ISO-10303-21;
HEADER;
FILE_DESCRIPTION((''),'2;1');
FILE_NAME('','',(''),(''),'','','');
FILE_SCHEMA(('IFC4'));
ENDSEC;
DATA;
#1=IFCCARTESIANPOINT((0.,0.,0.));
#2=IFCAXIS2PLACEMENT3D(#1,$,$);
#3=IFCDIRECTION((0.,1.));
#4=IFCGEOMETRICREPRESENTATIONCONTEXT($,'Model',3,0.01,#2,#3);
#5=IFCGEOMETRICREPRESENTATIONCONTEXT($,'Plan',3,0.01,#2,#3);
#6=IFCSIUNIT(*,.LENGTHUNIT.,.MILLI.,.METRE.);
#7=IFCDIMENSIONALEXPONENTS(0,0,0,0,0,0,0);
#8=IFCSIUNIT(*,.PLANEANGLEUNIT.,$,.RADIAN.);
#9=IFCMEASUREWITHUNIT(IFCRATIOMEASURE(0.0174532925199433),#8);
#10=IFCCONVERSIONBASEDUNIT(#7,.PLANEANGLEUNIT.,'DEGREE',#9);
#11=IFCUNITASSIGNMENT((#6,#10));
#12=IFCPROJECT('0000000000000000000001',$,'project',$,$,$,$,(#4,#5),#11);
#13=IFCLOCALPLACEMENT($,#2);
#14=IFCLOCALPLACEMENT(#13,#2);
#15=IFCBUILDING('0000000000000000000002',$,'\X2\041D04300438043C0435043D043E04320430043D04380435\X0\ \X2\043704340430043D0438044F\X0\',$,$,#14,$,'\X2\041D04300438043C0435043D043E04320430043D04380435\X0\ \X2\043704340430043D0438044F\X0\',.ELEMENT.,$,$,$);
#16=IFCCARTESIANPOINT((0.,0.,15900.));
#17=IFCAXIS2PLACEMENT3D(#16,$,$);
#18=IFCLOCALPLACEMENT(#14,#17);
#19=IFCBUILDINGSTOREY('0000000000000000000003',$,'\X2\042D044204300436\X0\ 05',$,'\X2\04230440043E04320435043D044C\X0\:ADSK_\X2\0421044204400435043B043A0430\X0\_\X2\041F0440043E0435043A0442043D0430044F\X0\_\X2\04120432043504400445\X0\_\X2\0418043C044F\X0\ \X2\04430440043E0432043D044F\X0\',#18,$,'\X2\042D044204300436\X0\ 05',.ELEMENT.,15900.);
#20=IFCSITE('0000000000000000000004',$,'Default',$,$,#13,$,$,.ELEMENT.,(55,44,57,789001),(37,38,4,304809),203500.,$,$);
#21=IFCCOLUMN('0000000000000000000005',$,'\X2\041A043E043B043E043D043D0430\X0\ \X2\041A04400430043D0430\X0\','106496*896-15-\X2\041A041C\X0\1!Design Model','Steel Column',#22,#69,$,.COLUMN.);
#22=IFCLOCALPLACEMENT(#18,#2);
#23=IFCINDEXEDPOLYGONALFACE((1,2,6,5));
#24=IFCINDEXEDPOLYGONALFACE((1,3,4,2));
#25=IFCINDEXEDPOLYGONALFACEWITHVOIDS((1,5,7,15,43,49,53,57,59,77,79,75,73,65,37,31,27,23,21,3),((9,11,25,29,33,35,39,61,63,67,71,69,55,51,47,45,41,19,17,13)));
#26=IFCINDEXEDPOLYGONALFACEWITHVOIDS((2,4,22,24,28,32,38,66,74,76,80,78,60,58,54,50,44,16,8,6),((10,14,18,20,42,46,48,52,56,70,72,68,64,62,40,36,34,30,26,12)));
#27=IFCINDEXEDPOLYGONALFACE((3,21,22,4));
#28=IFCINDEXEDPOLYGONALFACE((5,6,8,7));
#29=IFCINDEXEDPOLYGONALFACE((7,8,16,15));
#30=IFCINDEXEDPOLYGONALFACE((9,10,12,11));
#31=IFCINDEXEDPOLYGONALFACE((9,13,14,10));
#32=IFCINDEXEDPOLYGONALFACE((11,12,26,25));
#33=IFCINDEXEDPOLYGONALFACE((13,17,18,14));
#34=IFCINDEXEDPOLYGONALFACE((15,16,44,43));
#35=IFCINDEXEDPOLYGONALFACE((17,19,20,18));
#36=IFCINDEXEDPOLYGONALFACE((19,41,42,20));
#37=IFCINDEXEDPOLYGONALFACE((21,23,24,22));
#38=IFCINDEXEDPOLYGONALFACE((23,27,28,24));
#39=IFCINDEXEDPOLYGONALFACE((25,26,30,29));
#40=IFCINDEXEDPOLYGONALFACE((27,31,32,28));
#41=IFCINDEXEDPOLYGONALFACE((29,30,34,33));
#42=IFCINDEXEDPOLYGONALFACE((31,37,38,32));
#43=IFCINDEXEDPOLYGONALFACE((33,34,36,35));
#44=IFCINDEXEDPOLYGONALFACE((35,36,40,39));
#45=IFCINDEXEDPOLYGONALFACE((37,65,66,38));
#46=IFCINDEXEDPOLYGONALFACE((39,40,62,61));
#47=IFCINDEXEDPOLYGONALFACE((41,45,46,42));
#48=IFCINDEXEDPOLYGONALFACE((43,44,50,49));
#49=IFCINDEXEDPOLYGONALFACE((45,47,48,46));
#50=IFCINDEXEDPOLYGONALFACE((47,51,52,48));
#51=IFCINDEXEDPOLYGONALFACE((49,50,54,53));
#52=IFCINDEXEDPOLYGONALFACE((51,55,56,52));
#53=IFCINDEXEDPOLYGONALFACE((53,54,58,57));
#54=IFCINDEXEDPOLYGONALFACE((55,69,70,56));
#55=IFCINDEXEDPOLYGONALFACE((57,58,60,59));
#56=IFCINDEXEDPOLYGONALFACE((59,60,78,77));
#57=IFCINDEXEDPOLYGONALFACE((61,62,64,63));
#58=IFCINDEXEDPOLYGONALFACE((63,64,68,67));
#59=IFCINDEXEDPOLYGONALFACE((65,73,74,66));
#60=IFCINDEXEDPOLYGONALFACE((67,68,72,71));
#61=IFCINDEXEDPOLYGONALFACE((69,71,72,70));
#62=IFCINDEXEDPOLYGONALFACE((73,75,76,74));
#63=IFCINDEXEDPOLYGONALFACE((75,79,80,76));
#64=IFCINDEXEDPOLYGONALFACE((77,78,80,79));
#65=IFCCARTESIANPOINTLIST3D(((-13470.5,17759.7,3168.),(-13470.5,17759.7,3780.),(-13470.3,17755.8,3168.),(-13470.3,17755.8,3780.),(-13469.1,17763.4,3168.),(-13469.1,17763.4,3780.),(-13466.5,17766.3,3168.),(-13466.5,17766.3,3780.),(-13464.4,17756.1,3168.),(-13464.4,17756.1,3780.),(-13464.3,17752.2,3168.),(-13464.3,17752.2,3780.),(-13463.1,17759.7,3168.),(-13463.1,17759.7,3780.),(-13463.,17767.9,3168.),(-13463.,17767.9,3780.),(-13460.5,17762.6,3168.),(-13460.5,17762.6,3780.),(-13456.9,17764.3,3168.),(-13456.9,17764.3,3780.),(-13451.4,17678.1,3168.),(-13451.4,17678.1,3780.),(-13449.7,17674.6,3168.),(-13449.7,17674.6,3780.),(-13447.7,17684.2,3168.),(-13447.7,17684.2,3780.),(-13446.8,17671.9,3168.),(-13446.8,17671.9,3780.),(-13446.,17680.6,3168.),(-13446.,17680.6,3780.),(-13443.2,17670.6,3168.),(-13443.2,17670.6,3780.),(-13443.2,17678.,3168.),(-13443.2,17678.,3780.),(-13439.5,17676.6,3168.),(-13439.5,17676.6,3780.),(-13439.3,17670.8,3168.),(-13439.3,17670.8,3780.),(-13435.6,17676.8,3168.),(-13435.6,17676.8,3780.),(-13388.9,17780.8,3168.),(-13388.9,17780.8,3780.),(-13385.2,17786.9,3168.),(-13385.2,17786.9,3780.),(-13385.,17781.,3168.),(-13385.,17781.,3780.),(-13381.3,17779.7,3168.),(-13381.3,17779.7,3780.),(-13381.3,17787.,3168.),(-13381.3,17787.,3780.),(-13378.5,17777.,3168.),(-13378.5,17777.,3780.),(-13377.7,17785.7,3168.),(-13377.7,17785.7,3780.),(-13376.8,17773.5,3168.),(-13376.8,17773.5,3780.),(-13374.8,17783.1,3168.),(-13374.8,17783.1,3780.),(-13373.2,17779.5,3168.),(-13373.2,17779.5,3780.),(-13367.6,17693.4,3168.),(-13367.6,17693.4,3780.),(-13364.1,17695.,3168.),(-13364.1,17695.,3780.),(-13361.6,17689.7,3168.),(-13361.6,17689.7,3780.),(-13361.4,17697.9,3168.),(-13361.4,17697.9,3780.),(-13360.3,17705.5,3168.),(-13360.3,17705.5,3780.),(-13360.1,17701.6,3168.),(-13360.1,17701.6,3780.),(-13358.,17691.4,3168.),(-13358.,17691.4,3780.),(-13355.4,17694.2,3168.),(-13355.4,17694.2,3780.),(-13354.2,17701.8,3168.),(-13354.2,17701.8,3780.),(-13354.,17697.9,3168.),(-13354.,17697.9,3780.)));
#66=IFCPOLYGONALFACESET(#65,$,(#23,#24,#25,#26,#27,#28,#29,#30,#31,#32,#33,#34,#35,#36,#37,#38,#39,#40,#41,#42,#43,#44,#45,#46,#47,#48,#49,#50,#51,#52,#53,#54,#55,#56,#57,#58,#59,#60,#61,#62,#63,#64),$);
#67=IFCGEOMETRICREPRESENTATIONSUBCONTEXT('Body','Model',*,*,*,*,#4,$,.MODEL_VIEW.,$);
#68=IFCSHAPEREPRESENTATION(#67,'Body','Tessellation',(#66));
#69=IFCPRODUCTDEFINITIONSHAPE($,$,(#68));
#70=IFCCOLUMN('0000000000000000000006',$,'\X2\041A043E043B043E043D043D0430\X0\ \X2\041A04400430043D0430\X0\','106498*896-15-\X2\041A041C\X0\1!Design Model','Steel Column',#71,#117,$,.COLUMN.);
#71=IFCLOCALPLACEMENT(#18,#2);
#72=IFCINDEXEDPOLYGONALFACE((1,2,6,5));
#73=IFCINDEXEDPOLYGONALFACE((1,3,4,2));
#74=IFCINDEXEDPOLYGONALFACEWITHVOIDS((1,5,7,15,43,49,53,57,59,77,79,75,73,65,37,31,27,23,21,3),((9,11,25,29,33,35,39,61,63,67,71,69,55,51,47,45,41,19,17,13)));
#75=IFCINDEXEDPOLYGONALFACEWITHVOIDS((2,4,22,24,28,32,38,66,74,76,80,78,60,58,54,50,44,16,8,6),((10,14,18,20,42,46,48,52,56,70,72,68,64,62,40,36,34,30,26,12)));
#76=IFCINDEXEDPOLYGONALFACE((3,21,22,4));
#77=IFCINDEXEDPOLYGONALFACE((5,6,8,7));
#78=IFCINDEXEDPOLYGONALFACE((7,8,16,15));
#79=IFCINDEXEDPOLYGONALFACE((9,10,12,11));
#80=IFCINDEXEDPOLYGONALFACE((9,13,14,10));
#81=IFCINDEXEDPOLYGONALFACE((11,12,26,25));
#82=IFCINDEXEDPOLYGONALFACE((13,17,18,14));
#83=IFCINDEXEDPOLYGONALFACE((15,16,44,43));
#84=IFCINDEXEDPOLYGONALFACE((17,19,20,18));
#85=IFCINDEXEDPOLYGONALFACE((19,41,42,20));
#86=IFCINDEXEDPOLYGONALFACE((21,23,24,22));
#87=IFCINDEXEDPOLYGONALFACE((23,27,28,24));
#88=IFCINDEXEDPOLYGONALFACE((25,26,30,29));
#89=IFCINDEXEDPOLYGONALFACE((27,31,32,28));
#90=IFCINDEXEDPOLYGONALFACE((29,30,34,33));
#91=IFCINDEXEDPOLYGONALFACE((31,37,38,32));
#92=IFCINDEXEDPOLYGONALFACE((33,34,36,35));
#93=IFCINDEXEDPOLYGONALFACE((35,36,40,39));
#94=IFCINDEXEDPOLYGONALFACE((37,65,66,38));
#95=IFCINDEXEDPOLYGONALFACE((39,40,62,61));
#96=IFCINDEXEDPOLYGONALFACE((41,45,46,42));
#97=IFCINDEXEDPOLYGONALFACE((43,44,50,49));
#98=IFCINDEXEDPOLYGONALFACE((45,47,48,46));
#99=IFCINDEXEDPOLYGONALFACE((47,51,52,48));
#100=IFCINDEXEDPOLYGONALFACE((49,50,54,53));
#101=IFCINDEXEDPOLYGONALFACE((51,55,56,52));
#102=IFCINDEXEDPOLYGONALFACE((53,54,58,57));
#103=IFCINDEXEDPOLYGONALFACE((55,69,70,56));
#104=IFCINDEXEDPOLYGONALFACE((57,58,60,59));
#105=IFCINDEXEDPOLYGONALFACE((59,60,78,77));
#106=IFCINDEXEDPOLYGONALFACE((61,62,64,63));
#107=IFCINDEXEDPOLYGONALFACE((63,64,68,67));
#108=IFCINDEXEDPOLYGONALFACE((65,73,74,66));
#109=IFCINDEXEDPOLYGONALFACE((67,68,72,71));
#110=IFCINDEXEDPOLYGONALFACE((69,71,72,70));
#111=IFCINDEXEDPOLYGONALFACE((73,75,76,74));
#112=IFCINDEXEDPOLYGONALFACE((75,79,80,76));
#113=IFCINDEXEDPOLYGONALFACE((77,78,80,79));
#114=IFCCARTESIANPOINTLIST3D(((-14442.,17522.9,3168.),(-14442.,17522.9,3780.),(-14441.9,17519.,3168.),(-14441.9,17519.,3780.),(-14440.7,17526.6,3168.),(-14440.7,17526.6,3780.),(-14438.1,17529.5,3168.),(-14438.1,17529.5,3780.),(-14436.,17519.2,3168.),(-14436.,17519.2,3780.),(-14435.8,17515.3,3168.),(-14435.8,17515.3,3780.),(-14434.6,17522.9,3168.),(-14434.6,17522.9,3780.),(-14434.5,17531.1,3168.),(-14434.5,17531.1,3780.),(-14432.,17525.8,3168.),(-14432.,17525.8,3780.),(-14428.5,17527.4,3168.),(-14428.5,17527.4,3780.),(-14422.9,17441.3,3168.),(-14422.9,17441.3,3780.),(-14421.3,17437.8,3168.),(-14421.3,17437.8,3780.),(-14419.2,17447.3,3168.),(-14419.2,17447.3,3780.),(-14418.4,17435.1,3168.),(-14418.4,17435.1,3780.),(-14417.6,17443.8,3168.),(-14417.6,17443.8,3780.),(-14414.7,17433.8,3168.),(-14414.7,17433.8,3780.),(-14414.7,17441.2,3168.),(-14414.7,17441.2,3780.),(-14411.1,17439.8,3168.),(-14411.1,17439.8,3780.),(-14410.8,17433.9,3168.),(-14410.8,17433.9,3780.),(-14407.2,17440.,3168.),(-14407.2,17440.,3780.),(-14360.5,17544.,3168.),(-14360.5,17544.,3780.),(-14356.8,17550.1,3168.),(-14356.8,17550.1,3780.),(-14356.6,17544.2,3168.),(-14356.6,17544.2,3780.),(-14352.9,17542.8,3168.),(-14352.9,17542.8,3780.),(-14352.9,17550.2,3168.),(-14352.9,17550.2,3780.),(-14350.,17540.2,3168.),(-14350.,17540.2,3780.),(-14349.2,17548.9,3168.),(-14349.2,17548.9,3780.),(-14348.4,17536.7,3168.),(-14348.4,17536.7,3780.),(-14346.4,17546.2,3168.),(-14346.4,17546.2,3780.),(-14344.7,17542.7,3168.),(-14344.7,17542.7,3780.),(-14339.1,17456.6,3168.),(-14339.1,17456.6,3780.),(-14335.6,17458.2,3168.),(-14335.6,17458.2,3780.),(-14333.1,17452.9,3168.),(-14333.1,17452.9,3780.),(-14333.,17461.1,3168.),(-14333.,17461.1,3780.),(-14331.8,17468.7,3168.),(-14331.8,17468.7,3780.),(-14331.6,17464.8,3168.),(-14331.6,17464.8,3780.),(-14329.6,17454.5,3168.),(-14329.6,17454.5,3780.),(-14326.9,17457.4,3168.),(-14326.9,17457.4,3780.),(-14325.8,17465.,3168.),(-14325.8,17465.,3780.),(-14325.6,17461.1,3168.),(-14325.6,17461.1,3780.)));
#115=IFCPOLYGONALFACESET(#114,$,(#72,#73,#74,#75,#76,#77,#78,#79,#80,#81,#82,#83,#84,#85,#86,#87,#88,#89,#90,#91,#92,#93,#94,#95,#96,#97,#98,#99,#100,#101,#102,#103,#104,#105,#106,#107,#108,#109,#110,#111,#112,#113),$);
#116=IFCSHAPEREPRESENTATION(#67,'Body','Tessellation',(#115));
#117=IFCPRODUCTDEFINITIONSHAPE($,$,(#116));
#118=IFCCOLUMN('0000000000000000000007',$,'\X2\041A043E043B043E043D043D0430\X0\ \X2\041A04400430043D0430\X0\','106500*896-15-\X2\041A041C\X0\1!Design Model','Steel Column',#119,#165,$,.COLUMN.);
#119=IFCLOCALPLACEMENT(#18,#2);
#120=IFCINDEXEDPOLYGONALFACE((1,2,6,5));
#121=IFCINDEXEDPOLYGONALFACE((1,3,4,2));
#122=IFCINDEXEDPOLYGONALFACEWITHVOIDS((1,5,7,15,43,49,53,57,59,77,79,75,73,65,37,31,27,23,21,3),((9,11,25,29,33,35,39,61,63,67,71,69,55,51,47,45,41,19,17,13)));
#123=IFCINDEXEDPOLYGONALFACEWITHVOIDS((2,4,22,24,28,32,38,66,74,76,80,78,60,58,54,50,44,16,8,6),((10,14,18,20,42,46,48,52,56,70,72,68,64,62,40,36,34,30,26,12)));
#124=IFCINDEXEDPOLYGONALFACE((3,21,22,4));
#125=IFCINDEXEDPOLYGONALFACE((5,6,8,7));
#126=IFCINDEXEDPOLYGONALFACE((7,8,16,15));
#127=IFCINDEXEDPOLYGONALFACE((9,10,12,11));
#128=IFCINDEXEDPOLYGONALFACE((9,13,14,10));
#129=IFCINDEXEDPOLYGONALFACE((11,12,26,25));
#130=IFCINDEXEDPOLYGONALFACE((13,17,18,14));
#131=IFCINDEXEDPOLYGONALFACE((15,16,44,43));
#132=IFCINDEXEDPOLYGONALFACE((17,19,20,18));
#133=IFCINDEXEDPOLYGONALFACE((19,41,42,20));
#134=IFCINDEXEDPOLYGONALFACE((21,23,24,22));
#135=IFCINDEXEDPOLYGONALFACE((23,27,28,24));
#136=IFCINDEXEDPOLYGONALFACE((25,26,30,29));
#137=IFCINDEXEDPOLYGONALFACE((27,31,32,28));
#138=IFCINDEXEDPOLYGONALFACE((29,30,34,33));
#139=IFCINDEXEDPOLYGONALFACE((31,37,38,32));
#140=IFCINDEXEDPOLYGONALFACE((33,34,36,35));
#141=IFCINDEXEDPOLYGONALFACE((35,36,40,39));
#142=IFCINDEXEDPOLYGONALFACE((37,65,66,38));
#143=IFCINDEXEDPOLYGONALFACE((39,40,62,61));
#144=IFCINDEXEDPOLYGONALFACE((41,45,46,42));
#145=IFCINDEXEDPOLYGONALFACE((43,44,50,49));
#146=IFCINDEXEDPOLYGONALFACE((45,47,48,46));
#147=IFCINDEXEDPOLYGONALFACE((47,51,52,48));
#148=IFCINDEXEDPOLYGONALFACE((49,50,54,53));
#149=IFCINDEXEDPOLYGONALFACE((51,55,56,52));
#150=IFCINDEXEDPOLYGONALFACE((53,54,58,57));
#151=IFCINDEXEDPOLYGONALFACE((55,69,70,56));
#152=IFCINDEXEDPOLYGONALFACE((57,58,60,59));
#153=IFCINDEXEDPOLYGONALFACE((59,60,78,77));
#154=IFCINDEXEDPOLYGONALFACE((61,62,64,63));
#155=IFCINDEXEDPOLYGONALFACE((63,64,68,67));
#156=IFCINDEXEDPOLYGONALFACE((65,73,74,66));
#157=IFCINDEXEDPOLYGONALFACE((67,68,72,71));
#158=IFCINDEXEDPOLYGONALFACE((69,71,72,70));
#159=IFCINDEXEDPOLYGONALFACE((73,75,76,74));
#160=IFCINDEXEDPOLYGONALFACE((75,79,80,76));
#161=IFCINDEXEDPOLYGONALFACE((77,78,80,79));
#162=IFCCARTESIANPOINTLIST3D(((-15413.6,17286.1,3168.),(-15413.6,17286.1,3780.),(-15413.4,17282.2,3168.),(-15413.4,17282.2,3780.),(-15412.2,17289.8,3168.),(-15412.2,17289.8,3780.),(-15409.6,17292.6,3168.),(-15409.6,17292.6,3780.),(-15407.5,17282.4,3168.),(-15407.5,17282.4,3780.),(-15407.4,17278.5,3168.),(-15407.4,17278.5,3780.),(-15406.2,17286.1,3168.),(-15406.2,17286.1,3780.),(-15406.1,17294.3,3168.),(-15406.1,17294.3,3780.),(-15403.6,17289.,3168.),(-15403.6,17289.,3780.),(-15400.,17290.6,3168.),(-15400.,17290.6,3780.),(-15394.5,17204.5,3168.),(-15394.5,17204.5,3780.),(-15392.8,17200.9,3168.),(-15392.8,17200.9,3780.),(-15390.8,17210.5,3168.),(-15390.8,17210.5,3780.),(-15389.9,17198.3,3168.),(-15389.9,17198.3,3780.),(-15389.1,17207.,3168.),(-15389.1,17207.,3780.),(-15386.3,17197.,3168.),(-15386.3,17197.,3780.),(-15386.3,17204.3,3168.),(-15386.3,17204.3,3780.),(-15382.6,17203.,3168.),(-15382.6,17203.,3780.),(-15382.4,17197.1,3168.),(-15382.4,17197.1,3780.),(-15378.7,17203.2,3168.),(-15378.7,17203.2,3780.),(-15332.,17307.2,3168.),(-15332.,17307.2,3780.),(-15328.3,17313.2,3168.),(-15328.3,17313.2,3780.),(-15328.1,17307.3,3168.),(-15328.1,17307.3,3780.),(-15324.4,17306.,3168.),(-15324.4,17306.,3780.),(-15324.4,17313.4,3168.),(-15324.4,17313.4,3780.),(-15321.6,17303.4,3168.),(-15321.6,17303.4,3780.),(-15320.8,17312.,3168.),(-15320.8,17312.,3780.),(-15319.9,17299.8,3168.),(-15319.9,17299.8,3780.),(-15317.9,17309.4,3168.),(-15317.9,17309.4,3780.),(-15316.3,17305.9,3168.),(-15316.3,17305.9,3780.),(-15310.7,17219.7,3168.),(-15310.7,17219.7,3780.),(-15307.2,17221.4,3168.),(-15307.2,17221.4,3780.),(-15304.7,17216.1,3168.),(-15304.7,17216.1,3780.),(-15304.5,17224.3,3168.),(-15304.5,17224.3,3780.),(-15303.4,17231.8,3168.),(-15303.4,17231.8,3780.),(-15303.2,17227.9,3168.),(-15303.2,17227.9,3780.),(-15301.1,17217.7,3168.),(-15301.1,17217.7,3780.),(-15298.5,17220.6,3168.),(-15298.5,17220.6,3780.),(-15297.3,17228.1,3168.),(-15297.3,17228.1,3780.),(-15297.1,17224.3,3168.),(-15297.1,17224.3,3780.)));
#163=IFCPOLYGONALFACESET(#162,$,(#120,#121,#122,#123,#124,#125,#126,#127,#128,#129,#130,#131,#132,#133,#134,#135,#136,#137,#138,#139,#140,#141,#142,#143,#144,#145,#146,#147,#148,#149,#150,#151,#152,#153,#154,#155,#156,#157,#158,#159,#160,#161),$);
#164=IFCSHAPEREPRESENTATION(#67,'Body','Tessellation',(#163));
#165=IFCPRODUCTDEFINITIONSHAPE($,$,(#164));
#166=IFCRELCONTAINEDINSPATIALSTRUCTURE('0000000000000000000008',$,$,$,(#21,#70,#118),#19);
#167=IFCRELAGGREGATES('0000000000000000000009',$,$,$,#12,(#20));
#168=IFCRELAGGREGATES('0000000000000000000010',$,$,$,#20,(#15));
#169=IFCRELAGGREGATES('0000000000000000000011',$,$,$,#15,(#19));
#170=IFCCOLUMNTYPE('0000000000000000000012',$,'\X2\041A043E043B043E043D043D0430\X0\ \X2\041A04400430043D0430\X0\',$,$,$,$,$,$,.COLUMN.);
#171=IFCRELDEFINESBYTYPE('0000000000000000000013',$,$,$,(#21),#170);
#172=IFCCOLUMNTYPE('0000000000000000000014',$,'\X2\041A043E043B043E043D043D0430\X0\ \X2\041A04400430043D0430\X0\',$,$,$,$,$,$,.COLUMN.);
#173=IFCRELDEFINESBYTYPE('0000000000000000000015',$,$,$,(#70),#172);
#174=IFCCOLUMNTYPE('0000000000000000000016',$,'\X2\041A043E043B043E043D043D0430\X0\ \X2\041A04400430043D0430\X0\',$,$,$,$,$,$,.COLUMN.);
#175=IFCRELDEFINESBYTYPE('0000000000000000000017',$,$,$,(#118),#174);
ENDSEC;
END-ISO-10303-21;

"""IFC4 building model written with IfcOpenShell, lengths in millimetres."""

from ifc_helpers import new_model, entity, si_unit, converted_unit, direction, frame, origin, place, context, subcontext, project, spatial, indexed_curve, outline, extrude, type_object, element, save


model = new_model("IFC4")

# Units and contexts
model_context = context("Model", 3, precision=0.01, world=origin(), true_north=direction((0.0, 1.0)))
plan_context = context("Plan", 3, precision=0.01, world=origin(), true_north=direction((0.0, 1.0)))
body_context = subcontext(model_context, "Body", "Model", "MODEL_VIEW")
ifc_project = project(units=[si_unit("LENGTHUNIT", "METRE", prefix="MILLI"), converted_unit("PLANEANGLEUNIT", "DEGREE", entity("IfcRatioMeasure", 0.0174532925199433), si_unit("PLANEANGLEUNIT", "RADIAN"), dimensions=[0, 0, 0, 0, 0, 0, 0])], contexts=[model_context, plan_context])

# Site, building, storey
site_placement = place(None, origin())
site = spatial("IfcSite", under=ifc_project, at=site_placement, Name="Default", CompositionType="ELEMENT", RefLatitude=(55, 44, 57, 789001), RefLongitude=(37, 38, 4, 304809), RefElevation=203500.0)
building_placement = place(site_placement, origin())
building = spatial("IfcBuilding", under=site, at=building_placement, Name="Наименование здания", LongName="Наименование здания", CompositionType="ELEMENT")
storey_placement = place(building_placement, frame((0.0, 0.0, 15900.0)))
storey = spatial("IfcBuildingStorey", under=building, at=storey_placement, Name="Этаж 05", ObjectType="Уровень:ADSK_Стрелка_Проектная_Вверх_Имя уровня", LongName="Этаж 05", CompositionType="ELEMENT", Elevation=15900.0)

# Columns
placement = place(storey_placement, origin())
column_type_1 = type_object("IfcColumnType", Name="Колонна Крана", PredefinedType="COLUMN")
element("IfcColumn", 1, at=placement, inside=storey, type_object=column_type_1, Name="Колонна Крана", Description="106496*896-15-КМ1!Design Model", ObjectType="Steel Column", PredefinedType="COLUMN", context=body_context, shape_type="SweptSolid", body=[
    extrude(outline(indexed_curve([(29.5, -56.8), (33.4, -56.8), (37.0, -55.3), (39.7, -52.6), (41.2, -49.0), (56.8, 29.5), (56.8, 33.4), (55.3, 37.0), (52.6, 39.7), (49.0, 41.2), (-29.5, 56.8), (-33.4, 56.8), (-37.0, 55.3), (-39.7, 52.6), (-41.2, 49.0), (-56.8, -29.5), (-56.8, -33.4), (-55.3, -37.0), (-52.6, -39.7), (-49.0, -41.2), (29.5, -56.8)], self_intersect=False), holes=[indexed_curve([(-43.1, -37.3), (-46.7, -35.8), (-49.5, -33.1), (-51.0, -29.5), (-51.0, -25.5), (-37.3, 43.1), (-35.8, 46.7), (-33.1, 49.5), (-29.5, 51.0), (-25.5, 51.0), (43.1, 37.3), (46.7, 35.8), (49.5, 33.1), (51.0, 29.5), (51.0, 25.5), (37.3, -43.1), (35.8, -46.7), (33.1, -49.5), (29.5, -51.0), (25.5, -51.0), (-43.1, -37.3)], self_intersect=False)]), frame((-13412.3, 17728.8, 3168.0), z_axis=(0.0, 0.0, 1.0), x_axis=(0.906681, 0.421816, 0.0)), (0.0, 0.0, 1.0), 612.0),
])
column_type_2 = type_object("IfcColumnType", Name="Колонна Крана", PredefinedType="COLUMN")
element("IfcColumn", 2, at=placement, inside=storey, type_object=column_type_2, Name="Колонна Крана", Description="106498*896-15-КМ1!Design Model", ObjectType="Steel Column", PredefinedType="COLUMN", context=body_context, shape_type="SweptSolid", body=[
    extrude(outline(indexed_curve([(29.5, -56.8), (33.4, -56.8), (37.0, -55.3), (39.7, -52.6), (41.2, -49.0), (56.8, 29.5), (56.8, 33.4), (55.3, 37.0), (52.6, 39.7), (49.0, 41.2), (-29.5, 56.8), (-33.4, 56.8), (-37.0, 55.3), (-39.7, 52.6), (-41.2, 49.0), (-56.8, -29.5), (-56.8, -33.4), (-55.3, -37.0), (-52.6, -39.7), (-49.0, -41.2), (29.5, -56.8)], self_intersect=False), holes=[indexed_curve([(-43.1, -37.3), (-46.7, -35.8), (-49.5, -33.1), (-51.0, -29.5), (-51.0, -25.5), (-37.3, 43.1), (-35.8, 46.7), (-33.1, 49.5), (-29.5, 51.0), (-25.5, 51.0), (43.1, 37.3), (46.7, 35.8), (49.5, 33.1), (51.0, 29.5), (51.0, 25.5), (37.3, -43.1), (35.8, -46.7), (33.1, -49.5), (29.5, -51.0), (25.5, -51.0), (-43.1, -37.3)], self_intersect=False)]), frame((-14383.8, 17492.0, 3168.0), z_axis=(0.0, 0.0, 1.0), x_axis=(0.906681, 0.421816, 0.0)), (0.0, 0.0, 1.0), 612.0),
])
column_type_3 = type_object("IfcColumnType", Name="Колонна Крана", PredefinedType="COLUMN")
element("IfcColumn", 3, at=placement, inside=storey, type_object=column_type_3, Name="Колонна Крана", Description="106500*896-15-КМ1!Design Model", ObjectType="Steel Column", PredefinedType="COLUMN", context=body_context, shape_type="SweptSolid", body=[
    extrude(outline(indexed_curve([(29.5, -56.8), (33.4, -56.8), (37.0, -55.3), (39.7, -52.6), (41.2, -49.0), (56.8, 29.5), (56.8, 33.4), (55.3, 37.0), (52.6, 39.7), (49.0, 41.2), (-29.5, 56.8), (-33.4, 56.8), (-37.0, 55.3), (-39.7, 52.6), (-41.2, 49.0), (-56.8, -29.5), (-56.8, -33.4), (-55.3, -37.0), (-52.6, -39.7), (-49.0, -41.2), (29.5, -56.8)], self_intersect=False), holes=[indexed_curve([(-43.1, -37.3), (-46.7, -35.8), (-49.5, -33.1), (-51.0, -29.5), (-51.0, -25.5), (-37.3, 43.1), (-35.8, 46.7), (-33.1, 49.5), (-29.5, 51.0), (-25.5, 51.0), (43.1, 37.3), (46.7, 35.8), (49.5, 33.1), (51.0, 29.5), (51.0, 25.5), (37.3, -43.1), (35.8, -46.7), (33.1, -49.5), (29.5, -51.0), (25.5, -51.0), (-43.1, -37.3)], self_intersect=False)]), frame((-15355.4, 17255.2, 3168.0), z_axis=(0.0, 0.0, 1.0), x_axis=(0.906681, 0.421816, 0.0)), (0.0, 0.0, 1.0), 612.0),
])

save(model, "model.ifc")
